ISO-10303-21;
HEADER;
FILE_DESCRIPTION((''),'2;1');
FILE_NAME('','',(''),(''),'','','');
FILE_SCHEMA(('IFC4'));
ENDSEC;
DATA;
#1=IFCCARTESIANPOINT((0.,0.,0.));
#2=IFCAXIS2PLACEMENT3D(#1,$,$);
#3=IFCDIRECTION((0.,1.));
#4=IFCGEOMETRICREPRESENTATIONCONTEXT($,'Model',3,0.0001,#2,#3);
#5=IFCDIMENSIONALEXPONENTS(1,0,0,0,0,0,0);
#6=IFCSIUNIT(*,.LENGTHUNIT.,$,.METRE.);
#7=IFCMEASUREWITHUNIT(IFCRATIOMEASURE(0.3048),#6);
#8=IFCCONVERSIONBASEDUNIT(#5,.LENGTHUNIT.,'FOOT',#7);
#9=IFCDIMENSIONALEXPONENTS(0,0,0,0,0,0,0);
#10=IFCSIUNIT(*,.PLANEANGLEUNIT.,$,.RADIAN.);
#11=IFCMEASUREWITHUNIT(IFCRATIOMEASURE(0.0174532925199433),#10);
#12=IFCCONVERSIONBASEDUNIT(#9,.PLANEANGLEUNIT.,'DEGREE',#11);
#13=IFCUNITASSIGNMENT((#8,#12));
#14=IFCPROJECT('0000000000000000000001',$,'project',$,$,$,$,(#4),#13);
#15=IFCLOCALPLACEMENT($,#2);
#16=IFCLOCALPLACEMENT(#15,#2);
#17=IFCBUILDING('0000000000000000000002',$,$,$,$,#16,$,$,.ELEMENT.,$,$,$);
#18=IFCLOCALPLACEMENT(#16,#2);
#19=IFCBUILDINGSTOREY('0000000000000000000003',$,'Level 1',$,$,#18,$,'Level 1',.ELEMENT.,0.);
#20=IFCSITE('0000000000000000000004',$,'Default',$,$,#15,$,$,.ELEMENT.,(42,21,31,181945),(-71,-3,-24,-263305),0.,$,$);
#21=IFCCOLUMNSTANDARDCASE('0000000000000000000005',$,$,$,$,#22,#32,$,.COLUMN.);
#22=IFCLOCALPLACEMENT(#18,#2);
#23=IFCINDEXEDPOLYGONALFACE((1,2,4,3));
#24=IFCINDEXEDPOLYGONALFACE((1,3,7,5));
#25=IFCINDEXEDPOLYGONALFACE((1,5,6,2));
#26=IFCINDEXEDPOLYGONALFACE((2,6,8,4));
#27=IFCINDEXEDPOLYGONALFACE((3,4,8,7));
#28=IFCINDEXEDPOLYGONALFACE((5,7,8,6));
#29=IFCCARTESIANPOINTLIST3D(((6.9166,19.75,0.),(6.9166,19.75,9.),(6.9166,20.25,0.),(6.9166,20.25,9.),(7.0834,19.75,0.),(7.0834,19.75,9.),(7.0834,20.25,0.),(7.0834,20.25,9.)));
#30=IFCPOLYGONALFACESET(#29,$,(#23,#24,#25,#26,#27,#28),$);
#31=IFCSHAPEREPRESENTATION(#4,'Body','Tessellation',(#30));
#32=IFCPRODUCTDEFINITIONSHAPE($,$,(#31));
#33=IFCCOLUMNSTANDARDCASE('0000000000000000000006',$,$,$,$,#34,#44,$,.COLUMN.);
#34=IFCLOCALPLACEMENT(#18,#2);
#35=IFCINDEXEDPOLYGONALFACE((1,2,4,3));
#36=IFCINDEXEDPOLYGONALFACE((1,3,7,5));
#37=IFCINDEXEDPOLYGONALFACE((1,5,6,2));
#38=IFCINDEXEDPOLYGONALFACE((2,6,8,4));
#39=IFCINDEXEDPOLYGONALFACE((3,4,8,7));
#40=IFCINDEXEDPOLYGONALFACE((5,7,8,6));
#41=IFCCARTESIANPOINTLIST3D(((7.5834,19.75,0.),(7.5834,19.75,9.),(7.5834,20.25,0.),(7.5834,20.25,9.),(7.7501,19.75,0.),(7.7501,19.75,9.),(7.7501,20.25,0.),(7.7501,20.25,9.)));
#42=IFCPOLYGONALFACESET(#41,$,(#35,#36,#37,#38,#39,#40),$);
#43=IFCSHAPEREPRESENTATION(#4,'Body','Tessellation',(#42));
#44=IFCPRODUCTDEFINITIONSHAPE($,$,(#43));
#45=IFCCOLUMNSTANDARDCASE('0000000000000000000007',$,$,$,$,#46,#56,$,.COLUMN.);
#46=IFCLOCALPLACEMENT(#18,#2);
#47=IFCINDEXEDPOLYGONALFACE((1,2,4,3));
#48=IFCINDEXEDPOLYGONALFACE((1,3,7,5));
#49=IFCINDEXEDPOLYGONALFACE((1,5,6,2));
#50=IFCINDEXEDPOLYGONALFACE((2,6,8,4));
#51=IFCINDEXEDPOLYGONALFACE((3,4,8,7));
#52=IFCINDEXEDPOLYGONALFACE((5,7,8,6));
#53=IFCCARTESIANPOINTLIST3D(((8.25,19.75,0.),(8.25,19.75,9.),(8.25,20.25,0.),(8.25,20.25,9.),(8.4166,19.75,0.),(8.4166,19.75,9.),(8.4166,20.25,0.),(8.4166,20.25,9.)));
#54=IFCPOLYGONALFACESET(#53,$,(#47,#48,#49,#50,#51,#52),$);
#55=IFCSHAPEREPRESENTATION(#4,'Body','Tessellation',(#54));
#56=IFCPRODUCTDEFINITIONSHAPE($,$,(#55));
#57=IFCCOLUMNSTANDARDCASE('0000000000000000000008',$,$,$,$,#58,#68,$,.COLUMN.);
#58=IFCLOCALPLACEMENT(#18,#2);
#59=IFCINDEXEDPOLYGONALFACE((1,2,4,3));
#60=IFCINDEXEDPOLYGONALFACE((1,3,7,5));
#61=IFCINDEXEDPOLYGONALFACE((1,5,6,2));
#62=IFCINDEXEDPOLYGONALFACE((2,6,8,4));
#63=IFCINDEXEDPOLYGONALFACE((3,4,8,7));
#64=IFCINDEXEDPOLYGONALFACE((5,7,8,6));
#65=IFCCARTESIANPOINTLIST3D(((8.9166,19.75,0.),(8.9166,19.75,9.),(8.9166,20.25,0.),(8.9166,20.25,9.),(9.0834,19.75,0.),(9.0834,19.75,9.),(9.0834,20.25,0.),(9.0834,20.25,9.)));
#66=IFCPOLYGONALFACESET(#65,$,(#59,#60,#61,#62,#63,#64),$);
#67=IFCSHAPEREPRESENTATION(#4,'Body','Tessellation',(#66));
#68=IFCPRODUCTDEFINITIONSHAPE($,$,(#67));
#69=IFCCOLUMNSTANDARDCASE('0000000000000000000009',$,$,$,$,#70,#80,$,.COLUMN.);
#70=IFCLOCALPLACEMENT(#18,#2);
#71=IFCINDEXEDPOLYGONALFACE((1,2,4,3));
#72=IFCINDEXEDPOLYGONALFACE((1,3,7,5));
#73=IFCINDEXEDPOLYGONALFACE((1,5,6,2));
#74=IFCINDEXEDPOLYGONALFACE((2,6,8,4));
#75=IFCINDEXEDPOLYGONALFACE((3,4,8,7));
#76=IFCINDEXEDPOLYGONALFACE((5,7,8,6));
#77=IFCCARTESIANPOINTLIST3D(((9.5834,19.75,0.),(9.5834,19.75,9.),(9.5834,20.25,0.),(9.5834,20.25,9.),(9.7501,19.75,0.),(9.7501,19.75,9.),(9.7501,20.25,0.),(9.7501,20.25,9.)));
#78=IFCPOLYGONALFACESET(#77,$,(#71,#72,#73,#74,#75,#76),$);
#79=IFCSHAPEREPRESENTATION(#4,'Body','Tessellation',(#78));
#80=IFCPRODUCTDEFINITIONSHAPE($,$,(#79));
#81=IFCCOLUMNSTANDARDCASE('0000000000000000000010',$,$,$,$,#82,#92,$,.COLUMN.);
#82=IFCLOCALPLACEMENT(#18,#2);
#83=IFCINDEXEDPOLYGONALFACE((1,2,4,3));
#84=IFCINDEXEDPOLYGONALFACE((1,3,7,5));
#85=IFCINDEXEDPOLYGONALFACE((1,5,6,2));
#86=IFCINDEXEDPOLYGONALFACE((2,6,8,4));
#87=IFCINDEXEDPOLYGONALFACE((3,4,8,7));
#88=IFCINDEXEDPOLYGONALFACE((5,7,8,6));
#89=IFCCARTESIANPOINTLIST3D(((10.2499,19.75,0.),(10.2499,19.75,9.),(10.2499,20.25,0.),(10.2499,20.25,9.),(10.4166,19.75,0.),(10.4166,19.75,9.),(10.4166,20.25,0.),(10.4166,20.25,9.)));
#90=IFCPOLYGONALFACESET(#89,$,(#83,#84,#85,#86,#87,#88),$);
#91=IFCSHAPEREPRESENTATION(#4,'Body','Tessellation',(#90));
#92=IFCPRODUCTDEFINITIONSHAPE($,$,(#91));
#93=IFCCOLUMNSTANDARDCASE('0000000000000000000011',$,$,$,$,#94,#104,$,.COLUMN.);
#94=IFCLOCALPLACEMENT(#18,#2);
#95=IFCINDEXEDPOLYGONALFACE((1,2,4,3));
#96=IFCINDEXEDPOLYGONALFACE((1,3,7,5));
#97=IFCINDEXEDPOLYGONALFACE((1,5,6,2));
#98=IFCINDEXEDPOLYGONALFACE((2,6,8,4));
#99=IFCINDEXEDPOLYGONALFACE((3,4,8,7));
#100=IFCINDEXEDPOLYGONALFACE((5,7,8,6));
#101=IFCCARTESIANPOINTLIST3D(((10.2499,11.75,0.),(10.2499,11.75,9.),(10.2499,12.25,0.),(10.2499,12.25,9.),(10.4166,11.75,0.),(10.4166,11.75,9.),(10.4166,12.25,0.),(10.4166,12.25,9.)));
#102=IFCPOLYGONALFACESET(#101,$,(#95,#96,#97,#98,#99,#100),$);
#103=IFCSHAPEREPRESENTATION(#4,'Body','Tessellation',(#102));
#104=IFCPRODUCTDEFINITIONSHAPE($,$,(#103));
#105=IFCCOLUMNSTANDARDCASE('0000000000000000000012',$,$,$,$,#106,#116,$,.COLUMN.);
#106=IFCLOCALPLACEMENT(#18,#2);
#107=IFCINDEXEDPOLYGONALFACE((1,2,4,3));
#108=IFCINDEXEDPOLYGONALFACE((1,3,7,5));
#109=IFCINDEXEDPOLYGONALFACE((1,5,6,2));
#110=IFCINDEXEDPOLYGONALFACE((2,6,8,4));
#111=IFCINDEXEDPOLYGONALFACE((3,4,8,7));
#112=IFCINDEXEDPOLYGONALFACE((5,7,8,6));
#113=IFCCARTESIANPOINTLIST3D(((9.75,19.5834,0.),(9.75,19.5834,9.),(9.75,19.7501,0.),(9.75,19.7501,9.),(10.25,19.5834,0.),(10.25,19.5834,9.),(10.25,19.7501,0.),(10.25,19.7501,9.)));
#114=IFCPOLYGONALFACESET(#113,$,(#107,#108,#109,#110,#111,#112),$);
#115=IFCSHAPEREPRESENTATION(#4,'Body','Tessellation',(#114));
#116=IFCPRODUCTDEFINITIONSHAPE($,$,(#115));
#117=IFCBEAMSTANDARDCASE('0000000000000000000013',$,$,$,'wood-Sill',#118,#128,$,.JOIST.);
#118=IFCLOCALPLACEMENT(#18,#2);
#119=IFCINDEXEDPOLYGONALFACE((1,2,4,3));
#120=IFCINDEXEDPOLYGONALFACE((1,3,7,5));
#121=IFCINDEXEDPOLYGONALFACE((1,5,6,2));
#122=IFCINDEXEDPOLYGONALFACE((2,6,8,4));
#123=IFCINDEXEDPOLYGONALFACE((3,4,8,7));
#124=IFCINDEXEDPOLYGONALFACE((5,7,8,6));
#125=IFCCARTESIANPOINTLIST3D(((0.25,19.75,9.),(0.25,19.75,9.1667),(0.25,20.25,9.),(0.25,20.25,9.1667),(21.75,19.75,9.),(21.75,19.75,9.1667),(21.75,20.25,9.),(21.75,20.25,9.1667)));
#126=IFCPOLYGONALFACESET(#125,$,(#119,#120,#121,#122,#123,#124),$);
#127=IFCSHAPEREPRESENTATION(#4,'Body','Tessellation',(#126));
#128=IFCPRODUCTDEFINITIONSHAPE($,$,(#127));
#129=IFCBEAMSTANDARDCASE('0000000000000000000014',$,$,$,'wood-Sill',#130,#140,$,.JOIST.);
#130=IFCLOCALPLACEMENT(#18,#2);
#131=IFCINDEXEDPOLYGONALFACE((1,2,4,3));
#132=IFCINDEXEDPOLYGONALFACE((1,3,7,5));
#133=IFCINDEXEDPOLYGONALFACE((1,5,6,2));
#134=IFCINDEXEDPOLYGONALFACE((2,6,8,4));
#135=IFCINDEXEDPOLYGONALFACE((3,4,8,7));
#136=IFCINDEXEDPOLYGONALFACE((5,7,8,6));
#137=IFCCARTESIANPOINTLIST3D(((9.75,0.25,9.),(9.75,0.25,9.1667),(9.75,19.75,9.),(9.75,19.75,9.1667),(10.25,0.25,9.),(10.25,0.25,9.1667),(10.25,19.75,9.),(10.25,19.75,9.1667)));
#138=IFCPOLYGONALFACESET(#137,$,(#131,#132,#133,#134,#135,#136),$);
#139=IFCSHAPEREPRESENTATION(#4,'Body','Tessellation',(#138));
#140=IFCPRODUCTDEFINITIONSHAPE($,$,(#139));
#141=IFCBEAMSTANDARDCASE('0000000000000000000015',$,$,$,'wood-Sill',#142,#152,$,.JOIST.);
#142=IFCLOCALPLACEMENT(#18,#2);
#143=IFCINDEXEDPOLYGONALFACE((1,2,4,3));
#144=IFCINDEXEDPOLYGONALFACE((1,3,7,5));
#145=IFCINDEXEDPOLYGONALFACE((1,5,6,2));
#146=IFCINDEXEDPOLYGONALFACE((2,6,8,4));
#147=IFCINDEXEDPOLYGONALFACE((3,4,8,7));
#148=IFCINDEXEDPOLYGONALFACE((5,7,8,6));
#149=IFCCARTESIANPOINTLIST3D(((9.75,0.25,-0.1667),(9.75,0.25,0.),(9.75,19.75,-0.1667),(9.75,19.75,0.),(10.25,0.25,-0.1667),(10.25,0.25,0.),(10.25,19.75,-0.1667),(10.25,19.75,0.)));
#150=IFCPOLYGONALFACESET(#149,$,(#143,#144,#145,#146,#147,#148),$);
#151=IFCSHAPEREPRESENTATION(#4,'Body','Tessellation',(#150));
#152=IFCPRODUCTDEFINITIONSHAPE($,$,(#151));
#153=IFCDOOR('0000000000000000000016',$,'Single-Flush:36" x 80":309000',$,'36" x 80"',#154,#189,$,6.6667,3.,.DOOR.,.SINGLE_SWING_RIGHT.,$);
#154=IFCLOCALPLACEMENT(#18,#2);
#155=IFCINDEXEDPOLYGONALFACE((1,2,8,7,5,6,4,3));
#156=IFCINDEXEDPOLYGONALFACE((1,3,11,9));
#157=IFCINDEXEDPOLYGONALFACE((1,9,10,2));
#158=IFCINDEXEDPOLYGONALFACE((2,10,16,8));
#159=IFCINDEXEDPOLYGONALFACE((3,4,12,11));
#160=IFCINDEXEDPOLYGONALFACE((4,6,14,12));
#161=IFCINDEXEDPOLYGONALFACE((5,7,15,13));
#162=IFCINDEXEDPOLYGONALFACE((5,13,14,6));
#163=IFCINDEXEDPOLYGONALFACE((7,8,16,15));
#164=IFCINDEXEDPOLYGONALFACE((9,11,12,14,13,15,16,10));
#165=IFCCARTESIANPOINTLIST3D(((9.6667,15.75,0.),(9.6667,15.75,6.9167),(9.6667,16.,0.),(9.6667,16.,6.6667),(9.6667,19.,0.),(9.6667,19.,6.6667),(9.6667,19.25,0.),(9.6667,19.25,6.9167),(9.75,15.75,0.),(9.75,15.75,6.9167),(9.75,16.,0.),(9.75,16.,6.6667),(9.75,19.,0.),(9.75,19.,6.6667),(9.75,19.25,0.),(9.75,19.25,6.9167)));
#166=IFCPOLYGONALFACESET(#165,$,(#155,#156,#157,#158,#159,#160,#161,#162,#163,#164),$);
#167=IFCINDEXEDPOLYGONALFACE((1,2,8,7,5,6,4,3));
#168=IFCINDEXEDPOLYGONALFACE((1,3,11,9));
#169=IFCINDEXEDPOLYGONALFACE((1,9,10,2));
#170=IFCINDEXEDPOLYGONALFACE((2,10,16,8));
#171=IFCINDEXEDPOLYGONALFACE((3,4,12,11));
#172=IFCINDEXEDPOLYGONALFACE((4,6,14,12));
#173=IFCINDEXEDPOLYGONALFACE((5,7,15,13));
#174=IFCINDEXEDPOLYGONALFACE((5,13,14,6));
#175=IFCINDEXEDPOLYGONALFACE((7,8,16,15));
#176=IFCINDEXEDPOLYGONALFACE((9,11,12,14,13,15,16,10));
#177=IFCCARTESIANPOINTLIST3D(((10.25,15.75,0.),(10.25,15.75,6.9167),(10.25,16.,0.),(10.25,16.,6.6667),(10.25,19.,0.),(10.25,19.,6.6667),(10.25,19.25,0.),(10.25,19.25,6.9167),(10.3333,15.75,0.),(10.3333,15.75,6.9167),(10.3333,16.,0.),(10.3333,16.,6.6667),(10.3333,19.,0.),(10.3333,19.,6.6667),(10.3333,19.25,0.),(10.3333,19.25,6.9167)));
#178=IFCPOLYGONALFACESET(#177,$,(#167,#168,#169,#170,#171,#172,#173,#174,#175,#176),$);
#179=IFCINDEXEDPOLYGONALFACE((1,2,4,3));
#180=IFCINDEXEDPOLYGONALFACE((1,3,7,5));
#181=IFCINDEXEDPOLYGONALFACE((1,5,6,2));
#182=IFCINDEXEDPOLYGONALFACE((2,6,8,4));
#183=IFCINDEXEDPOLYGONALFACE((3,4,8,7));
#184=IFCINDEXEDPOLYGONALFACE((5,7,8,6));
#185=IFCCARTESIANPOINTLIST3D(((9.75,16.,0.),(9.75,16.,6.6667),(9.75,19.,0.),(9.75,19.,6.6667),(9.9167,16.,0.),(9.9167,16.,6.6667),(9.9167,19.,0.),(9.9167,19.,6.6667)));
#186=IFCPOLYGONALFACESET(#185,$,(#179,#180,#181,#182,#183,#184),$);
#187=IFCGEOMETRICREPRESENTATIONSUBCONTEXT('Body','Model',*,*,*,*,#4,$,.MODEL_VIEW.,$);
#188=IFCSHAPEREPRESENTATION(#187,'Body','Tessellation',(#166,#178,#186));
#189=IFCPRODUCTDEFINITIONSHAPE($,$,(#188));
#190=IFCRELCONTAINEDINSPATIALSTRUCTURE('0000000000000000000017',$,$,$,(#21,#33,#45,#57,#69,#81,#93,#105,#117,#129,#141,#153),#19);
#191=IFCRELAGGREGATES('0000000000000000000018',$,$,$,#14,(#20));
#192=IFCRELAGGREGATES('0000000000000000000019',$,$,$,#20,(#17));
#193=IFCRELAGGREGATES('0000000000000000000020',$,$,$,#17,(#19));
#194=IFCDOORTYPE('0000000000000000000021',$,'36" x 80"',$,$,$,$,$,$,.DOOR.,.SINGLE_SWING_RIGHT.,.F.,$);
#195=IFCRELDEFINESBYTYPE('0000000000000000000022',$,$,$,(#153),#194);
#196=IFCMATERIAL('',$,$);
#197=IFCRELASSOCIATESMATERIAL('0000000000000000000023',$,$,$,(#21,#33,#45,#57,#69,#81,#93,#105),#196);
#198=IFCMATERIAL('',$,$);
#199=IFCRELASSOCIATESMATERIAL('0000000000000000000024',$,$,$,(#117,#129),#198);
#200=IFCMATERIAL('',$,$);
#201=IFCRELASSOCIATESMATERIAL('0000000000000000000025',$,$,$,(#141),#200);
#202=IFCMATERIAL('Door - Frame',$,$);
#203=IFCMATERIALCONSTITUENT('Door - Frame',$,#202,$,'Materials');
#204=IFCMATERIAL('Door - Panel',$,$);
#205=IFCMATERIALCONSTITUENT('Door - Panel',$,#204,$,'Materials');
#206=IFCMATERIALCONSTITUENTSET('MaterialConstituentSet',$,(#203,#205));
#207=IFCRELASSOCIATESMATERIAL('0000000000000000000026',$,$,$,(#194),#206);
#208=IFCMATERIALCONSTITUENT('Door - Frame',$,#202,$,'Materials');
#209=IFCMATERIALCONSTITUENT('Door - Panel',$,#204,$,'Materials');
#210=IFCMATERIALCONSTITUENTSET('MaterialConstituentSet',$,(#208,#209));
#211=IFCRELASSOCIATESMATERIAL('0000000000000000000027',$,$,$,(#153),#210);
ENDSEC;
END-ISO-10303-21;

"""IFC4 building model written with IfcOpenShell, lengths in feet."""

from ifc_helpers import new_model, entity, si_unit, converted_unit, direction, frame, origin, origin_2d_with_axis, place, context, subcontext, project, spatial, polyline, rectangle, outline, extrude, source, transform, mapped, material, constituent, constituent_set, type_object, type_shapes, element, save


model = new_model("IFC4")

# Units and contexts
model_context = context("Model", 3, precision=0.0001, world=origin(), true_north=direction((0.0, 1.0)))
body_context = subcontext(model_context, "Body", "Model", "MODEL_VIEW")
ifc_project = project(units=[converted_unit("LENGTHUNIT", "FOOT", entity("IfcRatioMeasure", 0.3048), si_unit("LENGTHUNIT", "METRE"), dimensions=[1, 0, 0, 0, 0, 0, 0]), converted_unit("PLANEANGLEUNIT", "DEGREE", entity("IfcRatioMeasure", 0.0174532925199433), si_unit("PLANEANGLEUNIT", "RADIAN"), dimensions=[0, 0, 0, 0, 0, 0, 0])], contexts=[model_context])

# Site, building, storey
site_placement = place(None, origin())
site = spatial("IfcSite", under=ifc_project, at=site_placement, Name="Default", CompositionType="ELEMENT", RefLatitude=(42, 21, 31, 181945), RefLongitude=(-71, -3, -24, -263305), RefElevation=0.0)
building_placement = place(site_placement, origin())
building = spatial("IfcBuilding", under=site, at=building_placement, CompositionType="ELEMENT")
storey_placement = place(building_placement, origin())
storey = spatial("IfcBuildingStorey", under=building, at=storey_placement, Name="Level 1", LongName="Level 1", CompositionType="ELEMENT", Elevation=0.0)

# Columns
ifc_material_1 = material(Name="")
placement_1 = place(storey_placement, frame((0.25, 20.0, 0.0)))
for number, where, z_axis, x_axis in (
    (1, (6.75, 0.0, 0.0), (0.0, 0.0, 1.0), (1.0, 0.0, 0.0)),
    (2, (7.4167, 0.0, 0.0), (0.0, 0.0, 1.0), (1.0, 0.0, 0.0)),
    (3, (8.0833, 0.0, 0.0), (0.0, 0.0, 1.0), (1.0, 0.0, 0.0)),
    (4, (8.75, 0.0, 0.0), (0.0, 0.0, 1.0), (1.0, 0.0, 0.0)),
    (5, (9.4167, 0.0, 0.0), (0.0, 0.0, 1.0), (1.0, 0.0, 0.0)),
    (6, (10.0833, 0.0, 0.0), (0.0, 0.0, 1.0), (1.0, 0.0, 0.0)),
):
    element("IfcColumnStandardCase", number, at=place(placement_1, frame(where, z_axis=z_axis, x_axis=x_axis)), inside=storey, material=ifc_material_1, PredefinedType="COLUMN", context=model_context, shape_type="SweptSolid", body=[
        extrude(rectangle(XDim=0.1667, YDim=0.5), origin(), (0.0, 0.0, 1.0), 9.0),
    ])
placement_2 = place(storey_placement, frame((10.25, 12.0, 0.0)))
for number, where, z_axis, x_axis in (
    (7, (0.0833, 0.0, 0.0), (0.0, 0.0, 1.0), (1.0, 0.0, 0.0)),
):
    element("IfcColumnStandardCase", number, at=place(placement_2, frame(where, z_axis=z_axis, x_axis=x_axis)), inside=storey, material=ifc_material_1, PredefinedType="COLUMN", context=model_context, shape_type="SweptSolid", body=[
        extrude(rectangle(XDim=0.1667, YDim=0.5), origin(), (0.0, 0.0, 1.0), 9.0),
    ])
placement_3 = place(storey_placement, frame((10.0, 19.75, 0.0), z_axis=(0.0, 0.0, 1.0), x_axis=(0.0, -1.0, 0.0)))
for number, where, z_axis, x_axis in (
    (8, (0.0833, 0.0, 0.0), (0.0, 0.0, 1.0), (1.0, 0.0, 0.0)),
):
    element("IfcColumnStandardCase", number, at=place(placement_3, frame(where, z_axis=z_axis, x_axis=x_axis)), inside=storey, material=ifc_material_1, PredefinedType="COLUMN", context=model_context, shape_type="SweptSolid", body=[
        extrude(rectangle(XDim=0.1667, YDim=0.5), origin(), (0.0, 0.0, 1.0), 9.0),
    ])

# Beams
ifc_material_2 = material(Name="")
beam_1_placement = place(placement_1, frame((10.75, 0.0, 9.0), z_axis=(0.0, 0.0, 1.0), x_axis=(1.0, 0.0, 0.0)))
element("IfcBeamStandardCase", 9, at=beam_1_placement, inside=storey, material=ifc_material_2, ObjectType="wood-Sill", PredefinedType="JOIST", context=model_context, shape_type="SweptSolid", body=[
    extrude(rectangle(XDim=21.5, YDim=0.5), origin(), (0.0, 0.0, 1.0), 0.1667),
])
beam_2_placement = place(placement_3, frame((9.75, 0.0, 9.0), z_axis=(0.0, 0.0, 1.0), x_axis=(1.0, 0.0, 0.0)))
element("IfcBeamStandardCase", 10, at=beam_2_placement, inside=storey, material=ifc_material_2, ObjectType="wood-Sill", PredefinedType="JOIST", context=model_context, shape_type="SweptSolid", body=[
    extrude(rectangle(XDim=19.5, YDim=0.5), origin(), (0.0, 0.0, 1.0), 0.1667),
])
ifc_material_3 = material(Name="")
beam_3_placement = place(placement_3, frame((9.75, 0.0, -0.1667), z_axis=(0.0, 0.0, 1.0), x_axis=(1.0, 0.0, 0.0)))
element("IfcBeamStandardCase", 11, at=beam_3_placement, inside=storey, material=ifc_material_3, ObjectType="wood-Sill", PredefinedType="JOIST", context=model_context, shape_type="SweptSolid", body=[
    extrude(rectangle(XDim=19.5, YDim=0.5), origin(), (0.0, 0.0, 1.0), 0.1667),
])

# Door
ifc_material_4 = material(Name="Door - Frame")
ifc_constituent_1 = constituent(ifc_material_4, Name="Door - Frame", Category="Materials")
ifc_material_5 = material(Name="Door - Panel")
ifc_constituent_2 = constituent(ifc_material_5, Name="Door - Panel", Category="Materials")
ifc_constituent_set_1 = constituent_set(constituents=[ifc_constituent_1, ifc_constituent_2], Name="MaterialConstituentSet")
ifc_constituent_3 = constituent(ifc_material_4, Name="Door - Frame", Category="Materials")
ifc_constituent_4 = constituent(ifc_material_5, Name="Door - Panel", Category="Materials")
ifc_constituent_set_2 = constituent_set(constituents=[ifc_constituent_3, ifc_constituent_4], Name="MaterialConstituentSet")
door_type = type_object("IfcDoorType", Name="36\" x 80\"", OperationType="SINGLE_SWING_RIGHT", ParameterTakesPrecedence=False, PredefinedType="DOOR", material=ifc_constituent_set_2)
shared_shape = source(origin(), body_context, "Body", "SweptSolid", [
    extrude(outline(polyline([(-1.75, -3.5208), (1.75, -3.5208), (1.75, 3.3958), (1.5, 3.3958), (1.5, -3.2708), (-1.5, -3.2708), (-1.5, 3.3958), (-1.75, 3.3958), (-1.75, -3.5208)])), frame((1.5, 0.5, 3.3958), z_axis=(0.0, 1.0, 0.0), x_axis=(1.0, 0.0, 0.0)), (0.0, 0.0, 1.0), 0.0833),
    extrude(outline(polyline([(-3.5208, -1.75), (3.3958, -1.75), (3.3958, -1.5), (-3.2708, -1.5), (-3.2708, 1.5), (3.3958, 1.5), (3.3958, 1.75), (-3.5208, 1.75), (-3.5208, -1.75)])), frame((1.5, -0.0833, 3.3958), z_axis=(0.0, 1.0, 0.0), x_axis=(0.0, 0.0, -1.0)), (0.0, 0.0, 1.0), 0.0833),
    extrude(rectangle(XDim=0.1667, YDim=3.0, at=origin_2d_with_axis()), frame((1.5, 0.4167, 0.0), z_axis=(0.0, 0.0, 1.0), x_axis=(0.0, 1.0, 0.0)), (0.0, 0.0, 1.0), 6.6667),
])
type_shapes(door_type, [shared_shape])
placement_4 = place(placement_3, frame((3.75, 0.25, 0.0)))
door_placement = place(placement_4, frame((0.0, 0.0, 0.0), z_axis=(0.0, 0.0, 1.0), x_axis=(-1.0, 0.0, 0.0)))
element("IfcDoor", 12, at=door_placement, inside=storey, type_object=door_type, material=ifc_constituent_set_1, Name="Single-Flush:36\" x 80\":309000", ObjectType="36\" x 80\"", OperationType="SINGLE_SWING_RIGHT", OverallHeight=6.6667, OverallWidth=3.0, PredefinedType="DOOR", context=body_context, shape_type="MappedRepresentation", body=[
    mapped(shared_shape, transform((0.0, 0.0, 0.0), scale=1.0)),
])

save(model, "model.ifc")
